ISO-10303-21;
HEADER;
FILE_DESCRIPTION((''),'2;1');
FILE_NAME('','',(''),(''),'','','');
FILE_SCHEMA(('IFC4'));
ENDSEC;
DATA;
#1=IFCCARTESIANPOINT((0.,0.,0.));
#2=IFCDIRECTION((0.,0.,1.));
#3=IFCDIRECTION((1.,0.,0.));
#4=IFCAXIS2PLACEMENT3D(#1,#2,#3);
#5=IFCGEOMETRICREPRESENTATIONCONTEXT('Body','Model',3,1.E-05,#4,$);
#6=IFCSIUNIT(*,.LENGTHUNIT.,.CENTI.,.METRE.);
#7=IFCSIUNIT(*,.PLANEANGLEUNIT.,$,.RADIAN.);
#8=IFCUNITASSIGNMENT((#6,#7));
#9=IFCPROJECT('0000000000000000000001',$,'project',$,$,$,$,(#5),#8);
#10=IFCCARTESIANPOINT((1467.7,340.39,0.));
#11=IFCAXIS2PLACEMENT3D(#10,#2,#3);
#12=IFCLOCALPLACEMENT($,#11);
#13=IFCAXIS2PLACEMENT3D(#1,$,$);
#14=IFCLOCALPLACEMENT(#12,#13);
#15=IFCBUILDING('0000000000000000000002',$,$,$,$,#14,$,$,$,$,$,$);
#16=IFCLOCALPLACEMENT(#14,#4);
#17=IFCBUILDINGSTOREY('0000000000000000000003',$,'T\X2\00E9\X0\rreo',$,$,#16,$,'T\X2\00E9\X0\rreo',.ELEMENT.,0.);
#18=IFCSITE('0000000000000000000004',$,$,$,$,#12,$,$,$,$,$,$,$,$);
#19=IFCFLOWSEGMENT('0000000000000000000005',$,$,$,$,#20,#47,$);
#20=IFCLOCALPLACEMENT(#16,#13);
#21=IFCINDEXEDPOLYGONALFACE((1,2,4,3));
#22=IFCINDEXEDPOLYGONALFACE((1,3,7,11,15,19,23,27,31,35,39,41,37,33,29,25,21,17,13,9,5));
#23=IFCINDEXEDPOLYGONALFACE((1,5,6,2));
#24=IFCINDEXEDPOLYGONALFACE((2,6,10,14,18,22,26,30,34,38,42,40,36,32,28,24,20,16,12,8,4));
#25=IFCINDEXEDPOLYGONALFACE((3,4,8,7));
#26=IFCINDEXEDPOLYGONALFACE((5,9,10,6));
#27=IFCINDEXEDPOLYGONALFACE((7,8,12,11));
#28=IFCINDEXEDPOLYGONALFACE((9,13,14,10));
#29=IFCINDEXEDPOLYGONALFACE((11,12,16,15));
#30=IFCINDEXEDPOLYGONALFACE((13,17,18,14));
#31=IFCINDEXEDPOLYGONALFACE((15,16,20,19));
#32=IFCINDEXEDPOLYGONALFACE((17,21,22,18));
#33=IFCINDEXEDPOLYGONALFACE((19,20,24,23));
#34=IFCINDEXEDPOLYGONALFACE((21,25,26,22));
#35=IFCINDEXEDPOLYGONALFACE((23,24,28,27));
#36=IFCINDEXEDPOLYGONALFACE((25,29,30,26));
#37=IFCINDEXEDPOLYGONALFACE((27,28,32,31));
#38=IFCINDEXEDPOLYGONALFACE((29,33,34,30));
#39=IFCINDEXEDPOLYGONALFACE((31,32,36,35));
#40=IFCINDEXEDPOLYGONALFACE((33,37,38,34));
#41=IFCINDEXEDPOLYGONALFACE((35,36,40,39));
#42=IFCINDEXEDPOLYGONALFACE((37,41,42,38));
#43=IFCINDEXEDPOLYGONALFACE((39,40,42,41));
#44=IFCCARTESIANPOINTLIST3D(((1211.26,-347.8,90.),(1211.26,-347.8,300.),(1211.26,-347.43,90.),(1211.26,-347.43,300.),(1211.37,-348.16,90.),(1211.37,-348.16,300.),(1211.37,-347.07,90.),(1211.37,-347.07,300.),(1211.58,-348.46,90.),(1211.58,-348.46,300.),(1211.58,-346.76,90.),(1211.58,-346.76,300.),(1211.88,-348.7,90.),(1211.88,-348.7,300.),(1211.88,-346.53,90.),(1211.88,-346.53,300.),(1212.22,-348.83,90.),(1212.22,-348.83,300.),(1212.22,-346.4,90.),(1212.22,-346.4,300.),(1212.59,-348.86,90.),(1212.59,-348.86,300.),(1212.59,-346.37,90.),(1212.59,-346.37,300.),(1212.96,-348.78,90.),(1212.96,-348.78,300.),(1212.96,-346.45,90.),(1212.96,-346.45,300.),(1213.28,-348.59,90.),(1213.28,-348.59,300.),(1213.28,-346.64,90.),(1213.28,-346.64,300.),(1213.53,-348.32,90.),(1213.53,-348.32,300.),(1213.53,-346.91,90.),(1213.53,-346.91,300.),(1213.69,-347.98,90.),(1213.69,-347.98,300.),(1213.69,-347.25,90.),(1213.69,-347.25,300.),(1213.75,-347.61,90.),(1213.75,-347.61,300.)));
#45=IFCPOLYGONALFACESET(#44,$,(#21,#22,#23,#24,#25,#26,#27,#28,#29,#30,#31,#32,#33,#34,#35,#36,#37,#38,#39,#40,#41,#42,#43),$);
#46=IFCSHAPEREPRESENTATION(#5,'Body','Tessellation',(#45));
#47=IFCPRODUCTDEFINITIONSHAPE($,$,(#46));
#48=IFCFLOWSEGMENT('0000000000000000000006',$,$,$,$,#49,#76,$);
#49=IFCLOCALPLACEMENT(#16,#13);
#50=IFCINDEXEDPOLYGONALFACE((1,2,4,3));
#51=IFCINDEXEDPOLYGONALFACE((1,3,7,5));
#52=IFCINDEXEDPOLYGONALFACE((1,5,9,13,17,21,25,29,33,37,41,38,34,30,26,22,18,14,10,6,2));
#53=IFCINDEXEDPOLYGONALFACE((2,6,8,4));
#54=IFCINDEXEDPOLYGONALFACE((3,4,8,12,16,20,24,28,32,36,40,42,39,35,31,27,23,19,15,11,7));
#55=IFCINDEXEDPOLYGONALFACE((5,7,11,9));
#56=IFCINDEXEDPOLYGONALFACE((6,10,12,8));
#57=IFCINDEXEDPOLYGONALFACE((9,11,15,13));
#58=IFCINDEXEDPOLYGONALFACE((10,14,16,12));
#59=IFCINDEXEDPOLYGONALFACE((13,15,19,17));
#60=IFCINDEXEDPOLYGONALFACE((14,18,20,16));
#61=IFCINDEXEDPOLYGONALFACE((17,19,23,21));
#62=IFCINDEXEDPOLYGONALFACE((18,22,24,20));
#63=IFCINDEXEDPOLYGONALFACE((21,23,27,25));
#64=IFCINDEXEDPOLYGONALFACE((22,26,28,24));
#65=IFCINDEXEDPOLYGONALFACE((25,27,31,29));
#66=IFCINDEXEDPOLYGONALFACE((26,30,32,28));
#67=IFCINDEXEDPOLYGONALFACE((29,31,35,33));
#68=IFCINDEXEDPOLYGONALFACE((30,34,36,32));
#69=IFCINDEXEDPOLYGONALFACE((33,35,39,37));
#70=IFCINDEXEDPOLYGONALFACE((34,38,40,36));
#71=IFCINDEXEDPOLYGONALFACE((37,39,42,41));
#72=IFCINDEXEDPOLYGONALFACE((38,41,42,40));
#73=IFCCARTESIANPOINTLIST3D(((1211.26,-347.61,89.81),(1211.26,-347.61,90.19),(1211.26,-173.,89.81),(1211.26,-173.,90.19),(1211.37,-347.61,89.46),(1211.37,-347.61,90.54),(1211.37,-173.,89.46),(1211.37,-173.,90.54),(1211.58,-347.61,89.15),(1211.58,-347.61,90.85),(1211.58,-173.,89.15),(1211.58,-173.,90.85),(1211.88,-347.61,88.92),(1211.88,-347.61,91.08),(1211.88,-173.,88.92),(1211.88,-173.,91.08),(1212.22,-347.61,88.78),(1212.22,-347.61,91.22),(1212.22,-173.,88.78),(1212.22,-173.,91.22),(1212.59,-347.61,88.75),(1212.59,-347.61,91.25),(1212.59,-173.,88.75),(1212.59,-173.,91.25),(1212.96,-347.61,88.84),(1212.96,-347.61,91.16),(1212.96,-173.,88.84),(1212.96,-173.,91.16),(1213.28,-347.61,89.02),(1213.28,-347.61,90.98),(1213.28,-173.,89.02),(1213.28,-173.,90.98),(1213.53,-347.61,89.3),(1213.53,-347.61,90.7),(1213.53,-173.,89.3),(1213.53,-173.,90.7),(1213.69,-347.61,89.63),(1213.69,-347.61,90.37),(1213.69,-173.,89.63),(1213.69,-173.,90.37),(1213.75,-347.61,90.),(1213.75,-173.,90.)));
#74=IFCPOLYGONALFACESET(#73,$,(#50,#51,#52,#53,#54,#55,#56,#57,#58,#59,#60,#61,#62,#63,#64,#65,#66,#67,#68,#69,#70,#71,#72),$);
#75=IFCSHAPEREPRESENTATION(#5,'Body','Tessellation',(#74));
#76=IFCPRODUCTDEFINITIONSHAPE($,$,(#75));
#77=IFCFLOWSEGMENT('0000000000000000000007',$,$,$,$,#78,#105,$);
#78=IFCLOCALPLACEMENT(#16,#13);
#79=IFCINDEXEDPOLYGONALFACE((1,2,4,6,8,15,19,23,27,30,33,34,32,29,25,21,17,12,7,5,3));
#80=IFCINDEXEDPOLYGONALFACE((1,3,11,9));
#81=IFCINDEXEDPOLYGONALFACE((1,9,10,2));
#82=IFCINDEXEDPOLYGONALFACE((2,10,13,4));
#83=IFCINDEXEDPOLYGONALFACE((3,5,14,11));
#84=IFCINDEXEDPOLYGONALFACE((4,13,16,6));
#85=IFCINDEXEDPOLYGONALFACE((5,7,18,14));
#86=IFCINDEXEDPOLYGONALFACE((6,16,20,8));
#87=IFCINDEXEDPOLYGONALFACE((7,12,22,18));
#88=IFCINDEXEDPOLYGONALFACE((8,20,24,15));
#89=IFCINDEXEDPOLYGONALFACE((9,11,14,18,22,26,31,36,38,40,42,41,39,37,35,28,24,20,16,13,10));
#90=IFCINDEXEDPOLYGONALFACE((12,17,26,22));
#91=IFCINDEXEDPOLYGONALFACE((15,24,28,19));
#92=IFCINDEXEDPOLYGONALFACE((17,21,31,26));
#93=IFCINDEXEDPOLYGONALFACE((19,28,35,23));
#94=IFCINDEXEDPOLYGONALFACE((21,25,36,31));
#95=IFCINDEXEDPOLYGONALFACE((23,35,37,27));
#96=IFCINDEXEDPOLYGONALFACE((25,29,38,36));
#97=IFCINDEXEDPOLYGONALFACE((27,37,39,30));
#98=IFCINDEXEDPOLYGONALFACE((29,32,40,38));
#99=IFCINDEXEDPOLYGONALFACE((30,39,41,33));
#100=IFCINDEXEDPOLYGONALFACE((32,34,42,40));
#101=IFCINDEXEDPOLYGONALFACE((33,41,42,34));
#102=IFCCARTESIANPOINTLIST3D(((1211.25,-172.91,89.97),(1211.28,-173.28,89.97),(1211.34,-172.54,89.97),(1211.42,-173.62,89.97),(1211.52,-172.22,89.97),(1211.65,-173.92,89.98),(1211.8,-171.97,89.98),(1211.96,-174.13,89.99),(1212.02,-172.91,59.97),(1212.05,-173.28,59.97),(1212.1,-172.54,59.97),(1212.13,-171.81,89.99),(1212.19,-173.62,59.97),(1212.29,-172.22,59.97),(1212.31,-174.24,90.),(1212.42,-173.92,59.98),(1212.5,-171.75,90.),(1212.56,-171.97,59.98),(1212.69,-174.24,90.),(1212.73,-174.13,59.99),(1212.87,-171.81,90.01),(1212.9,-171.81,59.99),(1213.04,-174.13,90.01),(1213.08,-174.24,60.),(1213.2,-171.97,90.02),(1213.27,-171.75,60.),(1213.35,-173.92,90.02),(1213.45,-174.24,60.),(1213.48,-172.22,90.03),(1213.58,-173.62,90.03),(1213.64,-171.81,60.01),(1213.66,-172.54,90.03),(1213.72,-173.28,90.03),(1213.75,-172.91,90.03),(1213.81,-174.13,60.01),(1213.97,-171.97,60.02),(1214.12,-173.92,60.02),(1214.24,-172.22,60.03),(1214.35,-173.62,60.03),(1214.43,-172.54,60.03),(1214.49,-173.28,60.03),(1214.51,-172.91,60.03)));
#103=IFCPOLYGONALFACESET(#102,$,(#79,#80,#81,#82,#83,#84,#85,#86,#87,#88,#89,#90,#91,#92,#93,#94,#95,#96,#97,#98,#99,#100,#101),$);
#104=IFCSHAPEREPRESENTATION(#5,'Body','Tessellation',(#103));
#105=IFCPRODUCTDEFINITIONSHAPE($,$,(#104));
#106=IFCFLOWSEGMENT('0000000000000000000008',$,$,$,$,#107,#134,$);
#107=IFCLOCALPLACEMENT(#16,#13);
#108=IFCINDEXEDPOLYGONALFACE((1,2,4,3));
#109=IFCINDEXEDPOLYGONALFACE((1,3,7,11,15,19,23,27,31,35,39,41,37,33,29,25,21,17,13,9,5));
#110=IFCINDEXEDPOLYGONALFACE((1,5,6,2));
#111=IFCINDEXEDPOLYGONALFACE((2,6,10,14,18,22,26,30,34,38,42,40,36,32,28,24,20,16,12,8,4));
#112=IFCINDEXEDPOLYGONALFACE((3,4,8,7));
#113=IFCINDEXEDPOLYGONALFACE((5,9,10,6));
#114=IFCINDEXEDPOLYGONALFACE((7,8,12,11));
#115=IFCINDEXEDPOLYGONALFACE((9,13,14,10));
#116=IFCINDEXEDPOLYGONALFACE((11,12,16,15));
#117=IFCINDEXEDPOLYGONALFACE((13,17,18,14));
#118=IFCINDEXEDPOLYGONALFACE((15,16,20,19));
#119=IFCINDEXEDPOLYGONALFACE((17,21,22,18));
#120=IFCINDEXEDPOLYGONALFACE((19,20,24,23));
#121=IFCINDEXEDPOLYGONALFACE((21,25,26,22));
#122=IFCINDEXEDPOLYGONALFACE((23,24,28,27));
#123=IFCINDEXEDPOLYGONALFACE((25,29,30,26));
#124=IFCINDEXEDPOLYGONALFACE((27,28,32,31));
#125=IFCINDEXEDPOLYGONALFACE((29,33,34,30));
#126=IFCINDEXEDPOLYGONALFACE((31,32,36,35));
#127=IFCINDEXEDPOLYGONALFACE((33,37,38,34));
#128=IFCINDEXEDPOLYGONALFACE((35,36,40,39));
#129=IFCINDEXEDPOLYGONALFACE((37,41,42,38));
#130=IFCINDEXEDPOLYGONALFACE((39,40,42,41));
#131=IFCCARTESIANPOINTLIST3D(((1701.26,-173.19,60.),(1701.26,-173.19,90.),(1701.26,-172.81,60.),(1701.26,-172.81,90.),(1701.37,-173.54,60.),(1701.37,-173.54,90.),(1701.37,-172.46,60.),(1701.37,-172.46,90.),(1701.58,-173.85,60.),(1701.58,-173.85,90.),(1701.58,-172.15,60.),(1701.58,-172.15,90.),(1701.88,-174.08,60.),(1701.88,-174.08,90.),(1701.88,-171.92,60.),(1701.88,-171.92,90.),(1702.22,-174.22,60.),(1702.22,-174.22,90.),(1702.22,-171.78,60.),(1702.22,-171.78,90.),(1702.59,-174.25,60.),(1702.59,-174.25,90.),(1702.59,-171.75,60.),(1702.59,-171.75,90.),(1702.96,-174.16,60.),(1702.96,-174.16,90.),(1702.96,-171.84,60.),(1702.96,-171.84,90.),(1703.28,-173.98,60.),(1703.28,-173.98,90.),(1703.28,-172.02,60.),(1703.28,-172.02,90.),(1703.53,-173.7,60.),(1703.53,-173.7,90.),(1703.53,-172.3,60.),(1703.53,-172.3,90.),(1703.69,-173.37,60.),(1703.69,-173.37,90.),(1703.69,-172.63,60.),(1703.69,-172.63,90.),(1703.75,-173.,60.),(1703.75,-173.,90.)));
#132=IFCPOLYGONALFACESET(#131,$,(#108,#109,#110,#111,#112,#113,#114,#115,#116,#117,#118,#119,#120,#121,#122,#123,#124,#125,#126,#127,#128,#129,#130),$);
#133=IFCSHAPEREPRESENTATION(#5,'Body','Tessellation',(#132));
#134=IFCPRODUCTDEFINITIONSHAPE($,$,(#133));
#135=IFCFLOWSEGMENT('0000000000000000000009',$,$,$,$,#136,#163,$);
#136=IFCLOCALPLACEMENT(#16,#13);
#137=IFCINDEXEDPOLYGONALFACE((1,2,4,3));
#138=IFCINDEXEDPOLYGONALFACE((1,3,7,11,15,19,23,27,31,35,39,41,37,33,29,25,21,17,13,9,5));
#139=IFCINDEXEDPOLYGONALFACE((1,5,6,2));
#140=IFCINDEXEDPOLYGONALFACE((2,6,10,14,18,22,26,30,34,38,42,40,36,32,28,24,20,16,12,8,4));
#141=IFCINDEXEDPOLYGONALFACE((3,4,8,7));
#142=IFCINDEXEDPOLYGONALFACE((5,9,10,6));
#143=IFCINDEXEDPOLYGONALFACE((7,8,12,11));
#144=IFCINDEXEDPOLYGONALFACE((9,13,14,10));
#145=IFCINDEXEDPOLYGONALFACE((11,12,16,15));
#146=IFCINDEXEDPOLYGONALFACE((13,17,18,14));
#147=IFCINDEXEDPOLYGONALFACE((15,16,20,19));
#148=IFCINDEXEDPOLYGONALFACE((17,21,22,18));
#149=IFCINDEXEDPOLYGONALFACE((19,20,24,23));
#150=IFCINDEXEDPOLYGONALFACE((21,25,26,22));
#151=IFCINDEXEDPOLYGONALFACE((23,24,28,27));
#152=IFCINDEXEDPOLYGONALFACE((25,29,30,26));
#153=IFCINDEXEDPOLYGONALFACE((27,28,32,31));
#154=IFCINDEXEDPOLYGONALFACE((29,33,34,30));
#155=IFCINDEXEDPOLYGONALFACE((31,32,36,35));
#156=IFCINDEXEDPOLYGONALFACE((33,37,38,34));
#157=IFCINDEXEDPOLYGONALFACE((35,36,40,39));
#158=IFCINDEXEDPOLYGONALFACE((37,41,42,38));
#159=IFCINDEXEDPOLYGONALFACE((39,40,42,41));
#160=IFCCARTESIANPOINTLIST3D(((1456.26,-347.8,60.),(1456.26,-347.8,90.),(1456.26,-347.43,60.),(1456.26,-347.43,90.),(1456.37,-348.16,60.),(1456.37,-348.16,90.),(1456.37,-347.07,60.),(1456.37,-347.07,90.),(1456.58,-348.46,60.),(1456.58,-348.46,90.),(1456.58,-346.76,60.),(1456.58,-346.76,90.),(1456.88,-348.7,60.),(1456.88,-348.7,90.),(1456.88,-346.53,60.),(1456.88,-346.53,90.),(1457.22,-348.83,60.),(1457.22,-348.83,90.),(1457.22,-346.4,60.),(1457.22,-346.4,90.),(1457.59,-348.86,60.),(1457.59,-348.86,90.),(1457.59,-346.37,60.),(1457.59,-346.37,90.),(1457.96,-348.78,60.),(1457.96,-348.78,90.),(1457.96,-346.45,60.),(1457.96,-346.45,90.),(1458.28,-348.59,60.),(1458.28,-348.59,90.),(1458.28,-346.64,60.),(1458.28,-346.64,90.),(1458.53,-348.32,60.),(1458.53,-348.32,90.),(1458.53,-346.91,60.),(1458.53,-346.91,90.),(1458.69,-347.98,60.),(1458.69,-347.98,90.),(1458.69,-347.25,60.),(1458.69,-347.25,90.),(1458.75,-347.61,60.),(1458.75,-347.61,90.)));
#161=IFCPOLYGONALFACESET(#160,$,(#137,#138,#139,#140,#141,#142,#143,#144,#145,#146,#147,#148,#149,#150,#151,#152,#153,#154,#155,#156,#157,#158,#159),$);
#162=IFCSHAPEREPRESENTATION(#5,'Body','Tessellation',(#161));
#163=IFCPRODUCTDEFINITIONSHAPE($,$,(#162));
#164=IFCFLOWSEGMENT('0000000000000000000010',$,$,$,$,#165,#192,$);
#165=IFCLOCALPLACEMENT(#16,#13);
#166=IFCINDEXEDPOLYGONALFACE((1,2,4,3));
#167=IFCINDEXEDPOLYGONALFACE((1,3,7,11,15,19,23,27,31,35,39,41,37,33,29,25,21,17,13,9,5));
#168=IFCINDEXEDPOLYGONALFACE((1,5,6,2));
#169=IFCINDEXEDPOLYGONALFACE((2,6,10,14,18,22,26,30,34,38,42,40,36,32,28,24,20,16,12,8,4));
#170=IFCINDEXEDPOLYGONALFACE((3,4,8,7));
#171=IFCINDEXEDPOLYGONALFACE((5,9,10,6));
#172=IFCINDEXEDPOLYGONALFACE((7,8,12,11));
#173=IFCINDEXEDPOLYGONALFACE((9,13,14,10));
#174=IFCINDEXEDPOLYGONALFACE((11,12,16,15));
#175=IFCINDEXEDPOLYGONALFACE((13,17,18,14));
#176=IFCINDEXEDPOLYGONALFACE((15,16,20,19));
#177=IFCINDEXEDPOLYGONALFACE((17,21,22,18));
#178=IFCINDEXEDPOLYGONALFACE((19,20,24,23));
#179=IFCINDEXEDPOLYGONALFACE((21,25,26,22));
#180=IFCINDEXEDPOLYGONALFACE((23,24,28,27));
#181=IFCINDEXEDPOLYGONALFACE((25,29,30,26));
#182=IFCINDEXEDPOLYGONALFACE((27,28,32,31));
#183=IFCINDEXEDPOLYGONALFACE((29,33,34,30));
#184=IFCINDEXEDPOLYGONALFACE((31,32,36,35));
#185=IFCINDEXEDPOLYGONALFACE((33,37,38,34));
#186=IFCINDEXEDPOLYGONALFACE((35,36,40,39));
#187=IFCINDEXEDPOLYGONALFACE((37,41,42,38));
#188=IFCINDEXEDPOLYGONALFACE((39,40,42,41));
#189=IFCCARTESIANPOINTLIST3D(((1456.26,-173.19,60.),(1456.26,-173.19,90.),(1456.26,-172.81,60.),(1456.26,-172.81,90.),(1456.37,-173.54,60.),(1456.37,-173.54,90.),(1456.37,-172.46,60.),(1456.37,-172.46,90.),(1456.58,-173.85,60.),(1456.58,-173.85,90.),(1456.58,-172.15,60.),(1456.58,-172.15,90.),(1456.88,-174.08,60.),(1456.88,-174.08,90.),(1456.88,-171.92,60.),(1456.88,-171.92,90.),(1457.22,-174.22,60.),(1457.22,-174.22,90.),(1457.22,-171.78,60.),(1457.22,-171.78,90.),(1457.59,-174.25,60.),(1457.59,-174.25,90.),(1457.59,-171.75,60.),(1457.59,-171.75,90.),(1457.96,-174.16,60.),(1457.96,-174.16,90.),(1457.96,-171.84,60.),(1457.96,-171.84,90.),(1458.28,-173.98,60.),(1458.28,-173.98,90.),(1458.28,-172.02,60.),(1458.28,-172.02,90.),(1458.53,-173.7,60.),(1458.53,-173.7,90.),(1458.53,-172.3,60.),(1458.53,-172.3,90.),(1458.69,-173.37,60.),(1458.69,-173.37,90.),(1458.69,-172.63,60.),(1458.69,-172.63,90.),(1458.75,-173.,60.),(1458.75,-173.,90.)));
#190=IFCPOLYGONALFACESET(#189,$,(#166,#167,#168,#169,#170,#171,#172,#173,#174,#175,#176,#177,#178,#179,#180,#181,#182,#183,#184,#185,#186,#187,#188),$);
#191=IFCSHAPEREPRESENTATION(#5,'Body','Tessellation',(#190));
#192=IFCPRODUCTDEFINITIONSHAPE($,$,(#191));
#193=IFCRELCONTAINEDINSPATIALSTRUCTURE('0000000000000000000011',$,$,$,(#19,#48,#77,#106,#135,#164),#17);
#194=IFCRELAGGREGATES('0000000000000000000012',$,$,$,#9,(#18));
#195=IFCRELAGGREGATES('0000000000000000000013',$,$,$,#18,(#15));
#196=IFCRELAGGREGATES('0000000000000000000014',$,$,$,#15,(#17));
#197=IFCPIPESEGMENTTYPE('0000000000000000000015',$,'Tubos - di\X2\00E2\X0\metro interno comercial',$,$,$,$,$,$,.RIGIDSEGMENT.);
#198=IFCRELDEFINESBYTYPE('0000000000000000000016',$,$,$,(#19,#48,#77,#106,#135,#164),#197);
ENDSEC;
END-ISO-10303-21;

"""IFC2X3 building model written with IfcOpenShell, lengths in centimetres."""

from ifc_helpers import new_model, si_unit, frame, origin, origin_with_axes, origin_2d_with_axis, place, context, project, spatial, circle, extrude, type_object, element, save


model = new_model("IFC2X3")

# Units and contexts
model_context = context("Model", 3, precision=1e-05, world=origin_with_axes(), identifier="Body")
ifc_project = project(units=[si_unit("LENGTHUNIT", "METRE", prefix="CENTI"), si_unit("PLANEANGLEUNIT", "RADIAN")], contexts=[model_context])

# Site, building, storey
site_placement = place(None, frame((1467.7, 340.39, 0.0), z_axis=(0.0, 0.0, 1.0), x_axis=(1.0, 0.0, 0.0)))
site = spatial("IfcSite", under=ifc_project, at=site_placement)
building_placement = place(site_placement, origin())
building = spatial("IfcBuilding", under=site, at=building_placement)
storey_placement = place(building_placement, origin_with_axes())
storey = spatial("IfcBuildingStorey", under=building, at=storey_placement, Name="Térreo", LongName="Térreo", CompositionType="ELEMENT", Elevation=0.0)

# Flow segments
pipe_segment_type_1 = type_object("IfcPipeSegmentType", Name="Tubos - diâmetro interno comercial", PredefinedType="RIGIDSEGMENT")
flow_segment_1_placement = place(storey_placement, frame((1212.5, -347.61, 300.0), z_axis=(0.0, 0.0, 1.0), x_axis=(1.0, 0.0, 0.0)))
element("IfcFlowSegment", 1, at=flow_segment_1_placement, inside=storey, type_object=pipe_segment_type_1, context=model_context, shape_type="SolidModel", body=[
    extrude(circle(Radius=1.25, at=origin_2d_with_axis()), frame((0.0, 0.0, 0.0), z_axis=(0.0, 0.0, -1.0), x_axis=(1.0, 0.0, 0.0)), (0.0, 0.0, 1.0), 210.0),
])
flow_segment_2_placement = place(storey_placement, frame((1212.5, -260.31, 91.25), z_axis=(0.0, 0.0, 1.0), x_axis=(1.0, 0.0, 0.0)))
element("IfcFlowSegment", 2, at=flow_segment_2_placement, inside=storey, type_object=pipe_segment_type_1, context=model_context, shape_type="SolidModel", body=[
    extrude(circle(Radius=1.25, at=origin_2d_with_axis()), frame((0.0, -87.31, -1.25), z_axis=(0.0, 1.0, 0.0), x_axis=(1.0, 0.0, 0.0)), (0.0, 0.0, 1.0), 174.61),
])
flow_segment_3_placement = place(storey_placement, frame((1212.88, -173.0, 90.03), z_axis=(0.0, 0.0, 1.0), x_axis=(1.0, 0.0, 0.0)))
element("IfcFlowSegment", 3, at=flow_segment_3_placement, inside=storey, type_object=pipe_segment_type_1, context=model_context, shape_type="SolidModel", body=[
    extrude(circle(Radius=1.25, at=origin_2d_with_axis()), frame((-0.38, 0.0, -0.03), z_axis=(0.025584, 0.0, -0.999673), x_axis=(0.0, 1.0, 0.0)), (0.0, 0.0, 1.0), 30.01),
])
for number, where, z_axis, x_axis in (
    (4, (1702.5, -173.0, 90.0), (0.0, 0.0, 1.0), (1.0, 0.0, 0.0)),
    (5, (1457.5, -347.61, 90.0), (0.0, 0.0, 1.0), (1.0, 0.0, 0.0)),
    (6, (1457.5, -173.0, 90.0), (0.0, 0.0, 1.0), (1.0, 0.0, 0.0)),
):
    element("IfcFlowSegment", number, at=place(storey_placement, frame(where, z_axis=z_axis, x_axis=x_axis)), inside=storey, type_object=pipe_segment_type_1, context=model_context, shape_type="SolidModel", body=[
        extrude(circle(Radius=1.25, at=origin_2d_with_axis()), frame((0.0, 0.0, 0.0), z_axis=(0.0, 0.0, -1.0), x_axis=(1.0, 0.0, 0.0)), (0.0, 0.0, 1.0), 30.0),
    ])

save(model, "model.ifc")
